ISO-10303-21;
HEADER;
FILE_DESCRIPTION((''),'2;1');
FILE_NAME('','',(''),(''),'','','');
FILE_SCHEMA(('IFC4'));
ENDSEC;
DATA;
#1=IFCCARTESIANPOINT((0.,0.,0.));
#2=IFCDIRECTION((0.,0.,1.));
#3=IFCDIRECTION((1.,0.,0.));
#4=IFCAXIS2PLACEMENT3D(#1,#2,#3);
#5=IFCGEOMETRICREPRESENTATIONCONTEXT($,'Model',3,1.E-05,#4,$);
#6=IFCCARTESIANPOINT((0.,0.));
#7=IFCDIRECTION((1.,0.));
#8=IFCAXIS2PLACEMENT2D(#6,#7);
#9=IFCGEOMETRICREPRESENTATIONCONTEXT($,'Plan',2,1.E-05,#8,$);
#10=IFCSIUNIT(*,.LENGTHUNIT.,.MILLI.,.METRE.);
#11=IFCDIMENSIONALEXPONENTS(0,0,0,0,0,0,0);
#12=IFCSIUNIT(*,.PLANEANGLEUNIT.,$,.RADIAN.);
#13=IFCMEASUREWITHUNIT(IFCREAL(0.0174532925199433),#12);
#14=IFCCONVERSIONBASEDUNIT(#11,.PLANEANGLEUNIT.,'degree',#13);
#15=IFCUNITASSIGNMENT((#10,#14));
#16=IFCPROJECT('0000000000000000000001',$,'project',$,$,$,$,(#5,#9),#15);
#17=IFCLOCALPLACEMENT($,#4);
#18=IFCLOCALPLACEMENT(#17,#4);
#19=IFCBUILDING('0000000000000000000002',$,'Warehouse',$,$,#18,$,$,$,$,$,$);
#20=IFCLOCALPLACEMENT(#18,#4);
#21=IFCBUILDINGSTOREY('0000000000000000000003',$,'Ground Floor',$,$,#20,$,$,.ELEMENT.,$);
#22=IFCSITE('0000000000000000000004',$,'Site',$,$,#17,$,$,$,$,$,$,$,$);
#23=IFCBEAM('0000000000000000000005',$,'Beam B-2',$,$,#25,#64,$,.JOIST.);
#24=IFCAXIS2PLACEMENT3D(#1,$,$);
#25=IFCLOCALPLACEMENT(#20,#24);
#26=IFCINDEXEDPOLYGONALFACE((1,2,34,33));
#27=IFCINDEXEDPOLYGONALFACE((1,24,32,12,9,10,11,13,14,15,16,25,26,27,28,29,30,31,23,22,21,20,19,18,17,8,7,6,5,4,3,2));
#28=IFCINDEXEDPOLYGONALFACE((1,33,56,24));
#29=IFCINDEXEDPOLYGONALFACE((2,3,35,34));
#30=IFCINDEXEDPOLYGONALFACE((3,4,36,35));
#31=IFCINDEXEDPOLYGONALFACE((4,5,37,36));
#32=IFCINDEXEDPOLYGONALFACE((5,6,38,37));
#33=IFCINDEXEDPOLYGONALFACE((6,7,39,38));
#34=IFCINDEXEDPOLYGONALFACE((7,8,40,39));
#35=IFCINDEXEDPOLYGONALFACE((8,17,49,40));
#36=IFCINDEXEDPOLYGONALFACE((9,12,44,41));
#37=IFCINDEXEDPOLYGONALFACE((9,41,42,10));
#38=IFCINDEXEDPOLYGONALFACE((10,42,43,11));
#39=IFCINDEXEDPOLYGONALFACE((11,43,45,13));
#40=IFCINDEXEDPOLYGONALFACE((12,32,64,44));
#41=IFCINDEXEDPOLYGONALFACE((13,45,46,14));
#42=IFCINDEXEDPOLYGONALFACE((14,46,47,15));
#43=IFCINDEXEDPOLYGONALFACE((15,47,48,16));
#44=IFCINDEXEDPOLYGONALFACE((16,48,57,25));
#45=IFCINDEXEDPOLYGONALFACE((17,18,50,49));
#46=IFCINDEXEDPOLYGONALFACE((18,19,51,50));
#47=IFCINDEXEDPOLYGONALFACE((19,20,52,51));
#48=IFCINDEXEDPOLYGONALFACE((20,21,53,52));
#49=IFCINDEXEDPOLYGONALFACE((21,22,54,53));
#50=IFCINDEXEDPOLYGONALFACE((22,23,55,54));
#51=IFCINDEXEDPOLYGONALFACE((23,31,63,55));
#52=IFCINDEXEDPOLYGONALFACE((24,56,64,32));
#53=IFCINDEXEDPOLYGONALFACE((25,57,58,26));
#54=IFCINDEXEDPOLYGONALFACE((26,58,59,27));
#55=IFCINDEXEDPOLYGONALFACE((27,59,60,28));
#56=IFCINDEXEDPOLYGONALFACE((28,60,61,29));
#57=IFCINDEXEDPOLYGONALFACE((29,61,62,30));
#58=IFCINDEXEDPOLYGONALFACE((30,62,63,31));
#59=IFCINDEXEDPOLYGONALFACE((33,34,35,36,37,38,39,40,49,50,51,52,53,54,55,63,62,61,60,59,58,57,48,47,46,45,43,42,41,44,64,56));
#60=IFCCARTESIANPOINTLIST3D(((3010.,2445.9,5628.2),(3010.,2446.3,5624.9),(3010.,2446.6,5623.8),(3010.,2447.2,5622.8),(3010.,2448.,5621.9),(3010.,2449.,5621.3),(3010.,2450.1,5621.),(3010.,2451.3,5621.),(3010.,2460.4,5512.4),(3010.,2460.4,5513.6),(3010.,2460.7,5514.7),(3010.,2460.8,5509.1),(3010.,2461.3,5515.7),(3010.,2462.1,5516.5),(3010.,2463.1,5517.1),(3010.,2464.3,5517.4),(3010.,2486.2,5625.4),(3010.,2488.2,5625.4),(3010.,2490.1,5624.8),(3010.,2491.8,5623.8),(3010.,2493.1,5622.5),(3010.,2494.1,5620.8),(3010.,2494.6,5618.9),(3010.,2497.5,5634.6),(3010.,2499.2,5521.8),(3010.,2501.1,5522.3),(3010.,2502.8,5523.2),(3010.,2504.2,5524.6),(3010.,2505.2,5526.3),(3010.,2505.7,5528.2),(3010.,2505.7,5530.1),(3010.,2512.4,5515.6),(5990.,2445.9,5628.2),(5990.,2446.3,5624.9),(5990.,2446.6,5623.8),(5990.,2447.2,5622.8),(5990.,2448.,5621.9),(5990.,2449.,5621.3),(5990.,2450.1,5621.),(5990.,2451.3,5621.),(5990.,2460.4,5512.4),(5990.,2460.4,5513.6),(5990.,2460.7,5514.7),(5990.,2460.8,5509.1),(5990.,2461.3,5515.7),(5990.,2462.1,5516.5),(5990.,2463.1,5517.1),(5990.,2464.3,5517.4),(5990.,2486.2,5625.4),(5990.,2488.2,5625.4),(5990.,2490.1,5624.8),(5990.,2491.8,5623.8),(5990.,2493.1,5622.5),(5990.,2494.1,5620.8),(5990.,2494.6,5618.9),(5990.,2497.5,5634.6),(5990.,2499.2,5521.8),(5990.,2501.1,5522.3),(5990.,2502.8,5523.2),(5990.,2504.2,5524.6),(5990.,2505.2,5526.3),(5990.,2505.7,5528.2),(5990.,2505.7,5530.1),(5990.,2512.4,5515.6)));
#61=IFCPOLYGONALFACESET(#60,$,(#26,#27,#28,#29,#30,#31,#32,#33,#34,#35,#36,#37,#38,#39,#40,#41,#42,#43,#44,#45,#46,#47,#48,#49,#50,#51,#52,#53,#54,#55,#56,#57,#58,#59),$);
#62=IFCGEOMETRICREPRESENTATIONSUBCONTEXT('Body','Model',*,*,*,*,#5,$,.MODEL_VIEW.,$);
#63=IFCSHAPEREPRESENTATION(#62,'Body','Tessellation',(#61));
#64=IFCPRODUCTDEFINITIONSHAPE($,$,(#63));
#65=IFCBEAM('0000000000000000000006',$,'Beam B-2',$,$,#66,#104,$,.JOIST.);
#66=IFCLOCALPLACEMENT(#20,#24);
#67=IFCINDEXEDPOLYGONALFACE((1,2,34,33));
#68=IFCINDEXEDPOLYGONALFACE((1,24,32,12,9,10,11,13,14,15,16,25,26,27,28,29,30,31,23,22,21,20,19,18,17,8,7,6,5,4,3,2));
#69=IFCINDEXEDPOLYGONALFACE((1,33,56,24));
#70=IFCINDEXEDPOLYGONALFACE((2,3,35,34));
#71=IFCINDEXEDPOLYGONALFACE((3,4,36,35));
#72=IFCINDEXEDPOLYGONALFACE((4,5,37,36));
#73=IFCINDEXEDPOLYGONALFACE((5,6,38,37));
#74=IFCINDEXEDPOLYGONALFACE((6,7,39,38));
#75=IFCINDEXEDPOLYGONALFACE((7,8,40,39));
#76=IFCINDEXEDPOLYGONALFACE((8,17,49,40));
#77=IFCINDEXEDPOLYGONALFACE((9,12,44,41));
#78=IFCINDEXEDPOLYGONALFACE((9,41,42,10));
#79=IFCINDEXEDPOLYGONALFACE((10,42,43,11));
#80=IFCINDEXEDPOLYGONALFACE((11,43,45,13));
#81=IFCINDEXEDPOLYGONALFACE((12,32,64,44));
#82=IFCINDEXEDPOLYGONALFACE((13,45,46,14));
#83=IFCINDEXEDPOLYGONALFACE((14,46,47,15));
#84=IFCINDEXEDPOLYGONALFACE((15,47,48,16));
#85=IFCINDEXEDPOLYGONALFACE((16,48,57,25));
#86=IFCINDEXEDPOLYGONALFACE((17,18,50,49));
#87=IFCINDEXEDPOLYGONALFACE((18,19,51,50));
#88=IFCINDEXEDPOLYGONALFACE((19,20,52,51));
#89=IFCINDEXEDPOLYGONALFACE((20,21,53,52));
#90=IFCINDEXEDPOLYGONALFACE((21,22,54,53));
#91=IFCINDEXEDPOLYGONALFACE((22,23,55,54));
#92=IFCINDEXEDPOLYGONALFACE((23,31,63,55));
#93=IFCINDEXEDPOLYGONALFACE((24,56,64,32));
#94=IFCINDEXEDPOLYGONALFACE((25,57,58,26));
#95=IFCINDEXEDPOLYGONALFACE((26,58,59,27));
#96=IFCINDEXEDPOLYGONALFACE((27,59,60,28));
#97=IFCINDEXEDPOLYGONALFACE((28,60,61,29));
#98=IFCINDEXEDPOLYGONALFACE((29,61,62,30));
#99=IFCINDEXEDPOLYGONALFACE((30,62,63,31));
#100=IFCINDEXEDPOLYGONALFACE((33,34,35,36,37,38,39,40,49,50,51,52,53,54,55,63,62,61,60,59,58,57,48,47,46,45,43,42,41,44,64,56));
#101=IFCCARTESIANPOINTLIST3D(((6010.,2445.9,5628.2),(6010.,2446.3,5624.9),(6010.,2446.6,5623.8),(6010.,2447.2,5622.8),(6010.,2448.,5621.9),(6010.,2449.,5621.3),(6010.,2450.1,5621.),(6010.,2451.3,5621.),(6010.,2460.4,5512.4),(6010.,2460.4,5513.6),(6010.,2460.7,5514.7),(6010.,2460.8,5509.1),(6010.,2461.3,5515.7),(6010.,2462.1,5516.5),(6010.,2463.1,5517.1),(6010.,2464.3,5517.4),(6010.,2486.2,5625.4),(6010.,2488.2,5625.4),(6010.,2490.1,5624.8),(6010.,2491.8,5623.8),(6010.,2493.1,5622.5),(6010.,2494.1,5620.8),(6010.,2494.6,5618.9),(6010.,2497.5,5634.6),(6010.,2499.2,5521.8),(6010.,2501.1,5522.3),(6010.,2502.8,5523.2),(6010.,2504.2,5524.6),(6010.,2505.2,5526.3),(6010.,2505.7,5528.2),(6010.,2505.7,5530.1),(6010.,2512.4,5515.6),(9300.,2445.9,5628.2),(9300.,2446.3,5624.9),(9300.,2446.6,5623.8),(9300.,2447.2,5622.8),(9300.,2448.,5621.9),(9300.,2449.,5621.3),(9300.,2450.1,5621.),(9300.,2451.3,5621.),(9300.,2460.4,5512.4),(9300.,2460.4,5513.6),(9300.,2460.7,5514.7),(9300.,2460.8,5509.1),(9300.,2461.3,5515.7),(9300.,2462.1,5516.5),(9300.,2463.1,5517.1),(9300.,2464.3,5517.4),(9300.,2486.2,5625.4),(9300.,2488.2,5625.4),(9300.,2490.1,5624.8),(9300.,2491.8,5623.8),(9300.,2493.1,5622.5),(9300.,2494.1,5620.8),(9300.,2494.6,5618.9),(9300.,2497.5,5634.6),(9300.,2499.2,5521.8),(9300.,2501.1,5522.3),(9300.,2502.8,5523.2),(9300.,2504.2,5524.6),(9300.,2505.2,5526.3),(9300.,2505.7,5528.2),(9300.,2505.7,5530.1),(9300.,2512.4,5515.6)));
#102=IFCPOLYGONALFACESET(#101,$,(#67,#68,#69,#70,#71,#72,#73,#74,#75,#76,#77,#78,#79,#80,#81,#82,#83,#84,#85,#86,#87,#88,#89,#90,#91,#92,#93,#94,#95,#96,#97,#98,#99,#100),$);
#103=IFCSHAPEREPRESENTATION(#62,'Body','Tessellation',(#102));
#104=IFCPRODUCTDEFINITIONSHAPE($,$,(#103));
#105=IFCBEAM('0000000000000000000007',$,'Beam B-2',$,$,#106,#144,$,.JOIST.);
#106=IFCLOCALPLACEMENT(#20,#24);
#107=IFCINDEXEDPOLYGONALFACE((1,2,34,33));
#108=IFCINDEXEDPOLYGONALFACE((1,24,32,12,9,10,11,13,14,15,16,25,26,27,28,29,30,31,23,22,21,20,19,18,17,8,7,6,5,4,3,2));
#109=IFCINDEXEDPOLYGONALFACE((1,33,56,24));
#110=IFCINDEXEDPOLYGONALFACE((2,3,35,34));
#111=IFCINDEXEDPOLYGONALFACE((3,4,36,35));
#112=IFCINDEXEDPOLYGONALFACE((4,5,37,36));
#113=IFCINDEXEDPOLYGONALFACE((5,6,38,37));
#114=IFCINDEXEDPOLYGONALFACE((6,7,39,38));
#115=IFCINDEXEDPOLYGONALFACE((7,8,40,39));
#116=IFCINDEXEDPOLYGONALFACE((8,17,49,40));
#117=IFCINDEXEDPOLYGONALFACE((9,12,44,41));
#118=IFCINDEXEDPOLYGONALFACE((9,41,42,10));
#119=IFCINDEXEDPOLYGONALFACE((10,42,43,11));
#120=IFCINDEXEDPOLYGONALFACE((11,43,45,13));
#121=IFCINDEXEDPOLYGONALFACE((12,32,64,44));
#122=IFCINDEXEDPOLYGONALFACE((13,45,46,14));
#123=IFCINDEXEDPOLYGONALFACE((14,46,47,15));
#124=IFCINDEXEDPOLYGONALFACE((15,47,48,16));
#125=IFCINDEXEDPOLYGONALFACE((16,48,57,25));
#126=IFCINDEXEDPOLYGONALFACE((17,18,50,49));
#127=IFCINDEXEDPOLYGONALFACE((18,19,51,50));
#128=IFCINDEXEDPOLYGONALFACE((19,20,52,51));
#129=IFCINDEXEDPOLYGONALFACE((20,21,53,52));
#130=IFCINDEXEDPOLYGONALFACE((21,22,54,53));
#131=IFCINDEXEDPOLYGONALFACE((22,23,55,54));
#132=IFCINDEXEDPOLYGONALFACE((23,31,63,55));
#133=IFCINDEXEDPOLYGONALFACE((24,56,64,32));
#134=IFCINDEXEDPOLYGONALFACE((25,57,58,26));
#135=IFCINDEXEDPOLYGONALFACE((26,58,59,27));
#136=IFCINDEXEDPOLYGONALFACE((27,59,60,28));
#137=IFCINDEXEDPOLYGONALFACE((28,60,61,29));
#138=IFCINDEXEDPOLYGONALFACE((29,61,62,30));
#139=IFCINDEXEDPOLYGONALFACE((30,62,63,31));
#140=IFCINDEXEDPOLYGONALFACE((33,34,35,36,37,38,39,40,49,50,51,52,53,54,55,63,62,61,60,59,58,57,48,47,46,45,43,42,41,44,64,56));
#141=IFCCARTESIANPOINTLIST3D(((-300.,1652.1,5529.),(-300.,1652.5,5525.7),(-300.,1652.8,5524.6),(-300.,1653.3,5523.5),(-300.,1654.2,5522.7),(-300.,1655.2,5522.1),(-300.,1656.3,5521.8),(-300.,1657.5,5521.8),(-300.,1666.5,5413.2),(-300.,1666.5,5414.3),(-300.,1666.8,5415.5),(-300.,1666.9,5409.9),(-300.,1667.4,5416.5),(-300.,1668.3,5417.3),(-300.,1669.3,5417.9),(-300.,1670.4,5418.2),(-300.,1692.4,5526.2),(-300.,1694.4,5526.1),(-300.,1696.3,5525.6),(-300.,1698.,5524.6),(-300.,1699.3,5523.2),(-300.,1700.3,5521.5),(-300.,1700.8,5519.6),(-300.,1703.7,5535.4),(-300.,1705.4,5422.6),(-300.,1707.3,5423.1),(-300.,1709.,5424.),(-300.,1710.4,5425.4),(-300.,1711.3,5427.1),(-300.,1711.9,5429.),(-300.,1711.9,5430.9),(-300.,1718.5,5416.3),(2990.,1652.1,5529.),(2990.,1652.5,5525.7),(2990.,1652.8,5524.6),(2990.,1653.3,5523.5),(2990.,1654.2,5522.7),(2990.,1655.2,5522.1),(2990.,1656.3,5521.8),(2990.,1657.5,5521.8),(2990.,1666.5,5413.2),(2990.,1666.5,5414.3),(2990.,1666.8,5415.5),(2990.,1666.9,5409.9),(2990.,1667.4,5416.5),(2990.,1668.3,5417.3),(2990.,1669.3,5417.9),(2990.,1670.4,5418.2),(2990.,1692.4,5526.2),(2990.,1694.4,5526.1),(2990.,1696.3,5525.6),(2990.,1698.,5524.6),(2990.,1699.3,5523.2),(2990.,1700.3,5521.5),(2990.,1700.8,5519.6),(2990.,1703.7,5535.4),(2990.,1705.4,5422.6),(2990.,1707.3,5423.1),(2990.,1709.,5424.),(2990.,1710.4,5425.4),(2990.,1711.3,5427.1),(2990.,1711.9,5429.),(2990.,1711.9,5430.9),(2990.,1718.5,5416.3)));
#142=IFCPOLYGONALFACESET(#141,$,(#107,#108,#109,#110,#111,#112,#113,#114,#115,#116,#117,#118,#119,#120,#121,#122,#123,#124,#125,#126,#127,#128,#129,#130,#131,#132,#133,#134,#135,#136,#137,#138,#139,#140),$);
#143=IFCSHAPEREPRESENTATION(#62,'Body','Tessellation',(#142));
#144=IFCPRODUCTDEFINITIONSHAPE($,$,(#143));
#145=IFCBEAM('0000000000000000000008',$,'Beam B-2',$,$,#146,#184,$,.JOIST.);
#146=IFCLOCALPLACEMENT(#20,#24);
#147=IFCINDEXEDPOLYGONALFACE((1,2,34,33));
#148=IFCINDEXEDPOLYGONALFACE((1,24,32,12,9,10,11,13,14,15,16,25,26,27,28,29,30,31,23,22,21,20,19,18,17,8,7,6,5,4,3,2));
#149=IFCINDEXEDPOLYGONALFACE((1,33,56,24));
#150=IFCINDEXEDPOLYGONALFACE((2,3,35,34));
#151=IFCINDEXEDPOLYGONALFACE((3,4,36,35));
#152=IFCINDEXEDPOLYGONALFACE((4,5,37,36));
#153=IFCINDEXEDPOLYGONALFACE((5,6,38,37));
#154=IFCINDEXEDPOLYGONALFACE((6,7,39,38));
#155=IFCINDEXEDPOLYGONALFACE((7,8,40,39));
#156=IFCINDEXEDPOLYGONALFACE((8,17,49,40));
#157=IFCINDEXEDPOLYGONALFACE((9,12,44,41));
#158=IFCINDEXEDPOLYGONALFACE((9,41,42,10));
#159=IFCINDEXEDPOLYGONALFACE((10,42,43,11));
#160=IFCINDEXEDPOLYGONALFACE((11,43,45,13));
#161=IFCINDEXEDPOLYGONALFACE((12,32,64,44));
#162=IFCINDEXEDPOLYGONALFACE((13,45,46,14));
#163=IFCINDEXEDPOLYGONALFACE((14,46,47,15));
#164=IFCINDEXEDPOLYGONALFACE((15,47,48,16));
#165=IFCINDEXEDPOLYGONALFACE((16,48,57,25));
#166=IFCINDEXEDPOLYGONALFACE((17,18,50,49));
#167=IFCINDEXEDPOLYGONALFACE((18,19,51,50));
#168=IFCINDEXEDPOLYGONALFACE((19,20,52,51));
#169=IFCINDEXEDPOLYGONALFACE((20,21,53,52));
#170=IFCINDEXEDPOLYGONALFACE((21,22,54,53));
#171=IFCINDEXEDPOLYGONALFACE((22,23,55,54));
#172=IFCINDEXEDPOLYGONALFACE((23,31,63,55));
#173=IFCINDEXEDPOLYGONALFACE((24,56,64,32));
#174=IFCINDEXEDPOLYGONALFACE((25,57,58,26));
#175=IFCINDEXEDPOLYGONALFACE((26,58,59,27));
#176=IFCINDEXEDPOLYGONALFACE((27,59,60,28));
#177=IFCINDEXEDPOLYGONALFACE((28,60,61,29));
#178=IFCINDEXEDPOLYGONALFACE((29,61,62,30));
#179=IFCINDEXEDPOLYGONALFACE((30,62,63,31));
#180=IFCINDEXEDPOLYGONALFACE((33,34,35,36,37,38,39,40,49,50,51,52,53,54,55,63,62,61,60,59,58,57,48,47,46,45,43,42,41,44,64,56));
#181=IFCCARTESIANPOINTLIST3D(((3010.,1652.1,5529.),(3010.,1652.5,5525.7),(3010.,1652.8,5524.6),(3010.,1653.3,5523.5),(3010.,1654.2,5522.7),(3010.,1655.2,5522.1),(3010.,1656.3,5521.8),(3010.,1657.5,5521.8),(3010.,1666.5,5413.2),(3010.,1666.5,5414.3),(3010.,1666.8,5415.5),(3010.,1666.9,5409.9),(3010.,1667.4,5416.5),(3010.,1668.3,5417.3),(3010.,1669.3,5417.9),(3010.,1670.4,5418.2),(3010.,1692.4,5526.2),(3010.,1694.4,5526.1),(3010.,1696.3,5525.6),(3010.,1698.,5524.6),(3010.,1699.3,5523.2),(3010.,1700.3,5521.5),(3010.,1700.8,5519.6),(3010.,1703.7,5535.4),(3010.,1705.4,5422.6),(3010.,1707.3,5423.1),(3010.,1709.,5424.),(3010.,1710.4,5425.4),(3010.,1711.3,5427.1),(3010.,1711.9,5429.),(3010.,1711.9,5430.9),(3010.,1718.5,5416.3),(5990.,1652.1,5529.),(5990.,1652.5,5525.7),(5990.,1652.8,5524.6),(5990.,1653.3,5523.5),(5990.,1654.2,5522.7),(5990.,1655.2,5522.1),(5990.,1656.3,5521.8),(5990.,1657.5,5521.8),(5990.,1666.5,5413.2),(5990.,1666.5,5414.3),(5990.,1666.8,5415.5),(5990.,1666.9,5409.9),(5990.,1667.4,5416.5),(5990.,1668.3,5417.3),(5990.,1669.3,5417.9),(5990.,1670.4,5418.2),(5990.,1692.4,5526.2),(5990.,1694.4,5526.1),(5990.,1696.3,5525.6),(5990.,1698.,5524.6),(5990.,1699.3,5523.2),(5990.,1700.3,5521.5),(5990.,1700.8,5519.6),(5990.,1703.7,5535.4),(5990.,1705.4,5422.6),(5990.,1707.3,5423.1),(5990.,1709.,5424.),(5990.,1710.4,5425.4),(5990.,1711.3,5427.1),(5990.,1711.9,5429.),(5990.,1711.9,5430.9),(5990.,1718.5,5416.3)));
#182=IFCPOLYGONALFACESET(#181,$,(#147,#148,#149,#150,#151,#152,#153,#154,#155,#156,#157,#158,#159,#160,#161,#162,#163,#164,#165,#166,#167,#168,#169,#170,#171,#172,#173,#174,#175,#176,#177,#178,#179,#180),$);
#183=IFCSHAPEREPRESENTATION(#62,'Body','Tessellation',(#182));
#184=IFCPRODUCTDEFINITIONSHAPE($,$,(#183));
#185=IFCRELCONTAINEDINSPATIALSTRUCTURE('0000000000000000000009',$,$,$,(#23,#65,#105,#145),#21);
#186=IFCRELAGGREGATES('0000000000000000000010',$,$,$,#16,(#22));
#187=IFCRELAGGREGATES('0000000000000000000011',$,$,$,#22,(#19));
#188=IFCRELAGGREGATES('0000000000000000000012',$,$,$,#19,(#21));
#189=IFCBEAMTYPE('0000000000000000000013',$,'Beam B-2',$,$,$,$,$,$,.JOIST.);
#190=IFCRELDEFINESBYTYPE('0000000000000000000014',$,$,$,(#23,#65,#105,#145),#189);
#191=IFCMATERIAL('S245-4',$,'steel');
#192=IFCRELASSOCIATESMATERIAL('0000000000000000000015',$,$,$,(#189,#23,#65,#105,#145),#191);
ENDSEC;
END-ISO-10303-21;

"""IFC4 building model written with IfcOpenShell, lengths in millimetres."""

from ifc_helpers import new_model, entity, si_unit, converted_unit, frame, origin_with_axes, origin_2d_with_axis, place, context, subcontext, project, spatial, u_section, extrude, material, material_profile, profile_set, profile_usage, type_object, element, save


model = new_model("IFC4")

# Units and contexts
model_context = context("Model", 3, precision=1e-05, world=origin_with_axes())
plan_context = context("Plan", 2, precision=1e-05, world=origin_2d_with_axis())
body_context = subcontext(model_context, "Body", "Model", "MODEL_VIEW")
ifc_project = project(units=[si_unit("LENGTHUNIT", "METRE", prefix="MILLI"), converted_unit("PLANEANGLEUNIT", "degree", entity("IfcReal", 0.0174532925199433), si_unit("PLANEANGLEUNIT", "RADIAN"), dimensions=[0, 0, 0, 0, 0, 0, 0])], contexts=[model_context, plan_context])

# Site, building, storey
site_placement = place(None, origin_with_axes())
site = spatial("IfcSite", under=ifc_project, at=site_placement, Name="Site")
building_placement = place(site_placement, origin_with_axes())
building = spatial("IfcBuilding", under=site, at=building_placement, Name="Warehouse")
storey_placement = place(building_placement, origin_with_axes())
storey = spatial("IfcBuildingStorey", under=building, at=storey_placement, Name="Ground Floor", CompositionType="ELEMENT")

# Beams
ifc_material_1 = material(Name="S245-4", Category="steel")
ifc_material_profile_1 = material_profile(ifc_material_1, u_section(Depth=120.0, FlangeWidth=52.0, WebThickness=4.8, FlangeThickness=7.8, FilletRadius=7.5, EdgeRadius=4.5, FlangeSlope=0.0))
ifc_profile_set_1 = profile_set([ifc_material_profile_1], Name="U12P_S245-4")
beam_type_1 = type_object("IfcBeamType", Name="Beam B-2", PredefinedType="JOIST", material=ifc_profile_set_1)
ifc_profile_usage_1 = profile_usage(ifc_profile_set_1, cardinal=3)
beam_1_placement = place(storey_placement, frame((5990.0, 2512.4, 5515.6), z_axis=(-1.0, 0.0, 0.0), x_axis=(0.0, -0.99228, -0.12402)))
element("IfcBeam", 1, at=beam_1_placement, inside=storey, type_object=beam_type_1, material=ifc_profile_usage_1, Name="Beam B-2", PredefinedType="JOIST", context=body_context, shape_type="SweptSolid", body=[
    extrude(u_section(Depth=120.0, FlangeWidth=52.0, WebThickness=4.8, FlangeThickness=7.8, FilletRadius=7.5, EdgeRadius=4.5, FlangeSlope=0.0), frame((26.0, 60.0, 0.0), z_axis=(0.0, 0.0, 1.0), x_axis=(1.0, 0.0, 0.0)), (0.0, 0.0, 1.0), 2980.0),
])
ifc_profile_usage_2 = profile_usage(ifc_profile_set_1, cardinal=3)
beam_2_placement = place(storey_placement, frame((9300.0, 2512.4, 5515.6), z_axis=(-1.0, 0.0, 0.0), x_axis=(0.0, -0.99228, -0.12402)))
element("IfcBeam", 2, at=beam_2_placement, inside=storey, type_object=beam_type_1, material=ifc_profile_usage_2, Name="Beam B-2", PredefinedType="JOIST", context=body_context, shape_type="SweptSolid", body=[
    extrude(u_section(Depth=120.0, FlangeWidth=52.0, WebThickness=4.8, FlangeThickness=7.8, FilletRadius=7.5, EdgeRadius=4.5, FlangeSlope=0.0), frame((26.0, 60.0, 0.0), z_axis=(0.0, 0.0, 1.0), x_axis=(1.0, 0.0, 0.0)), (0.0, 0.0, 1.0), 3290.0),
])
ifc_profile_usage_3 = profile_usage(ifc_profile_set_1, cardinal=3)
beam_3_placement = place(storey_placement, frame((2990.0, 1718.5, 5416.3), z_axis=(-1.0, 0.0, 0.0), x_axis=(0.0, -0.99228, -0.124019)))
element("IfcBeam", 3, at=beam_3_placement, inside=storey, type_object=beam_type_1, material=ifc_profile_usage_3, Name="Beam B-2", PredefinedType="JOIST", context=body_context, shape_type="SweptSolid", body=[
    extrude(u_section(Depth=120.0, FlangeWidth=52.0, WebThickness=4.8, FlangeThickness=7.8, FilletRadius=7.5, EdgeRadius=4.5, FlangeSlope=0.0), frame((26.0, 60.0, 0.0), z_axis=(0.0, 0.0, 1.0), x_axis=(1.0, 0.0, 0.0)), (0.0, 0.0, 1.0), 3290.0),
])
ifc_profile_usage_4 = profile_usage(ifc_profile_set_1, cardinal=3)
beam_4_placement = place(storey_placement, frame((5990.0, 1718.5, 5416.3), z_axis=(-1.0, 0.0, 0.0), x_axis=(0.0, -0.99228, -0.12402)))
element("IfcBeam", 4, at=beam_4_placement, inside=storey, type_object=beam_type_1, material=ifc_profile_usage_4, Name="Beam B-2", PredefinedType="JOIST", context=body_context, shape_type="SweptSolid", body=[
    extrude(u_section(Depth=120.0, FlangeWidth=52.0, WebThickness=4.8, FlangeThickness=7.8, FilletRadius=7.5, EdgeRadius=4.5, FlangeSlope=0.0), frame((26.0, 60.0, 0.0), z_axis=(0.0, 0.0, 1.0), x_axis=(1.0, 0.0, 0.0)), (0.0, 0.0, 1.0), 2980.0),
])

save(model, "model.ifc")
